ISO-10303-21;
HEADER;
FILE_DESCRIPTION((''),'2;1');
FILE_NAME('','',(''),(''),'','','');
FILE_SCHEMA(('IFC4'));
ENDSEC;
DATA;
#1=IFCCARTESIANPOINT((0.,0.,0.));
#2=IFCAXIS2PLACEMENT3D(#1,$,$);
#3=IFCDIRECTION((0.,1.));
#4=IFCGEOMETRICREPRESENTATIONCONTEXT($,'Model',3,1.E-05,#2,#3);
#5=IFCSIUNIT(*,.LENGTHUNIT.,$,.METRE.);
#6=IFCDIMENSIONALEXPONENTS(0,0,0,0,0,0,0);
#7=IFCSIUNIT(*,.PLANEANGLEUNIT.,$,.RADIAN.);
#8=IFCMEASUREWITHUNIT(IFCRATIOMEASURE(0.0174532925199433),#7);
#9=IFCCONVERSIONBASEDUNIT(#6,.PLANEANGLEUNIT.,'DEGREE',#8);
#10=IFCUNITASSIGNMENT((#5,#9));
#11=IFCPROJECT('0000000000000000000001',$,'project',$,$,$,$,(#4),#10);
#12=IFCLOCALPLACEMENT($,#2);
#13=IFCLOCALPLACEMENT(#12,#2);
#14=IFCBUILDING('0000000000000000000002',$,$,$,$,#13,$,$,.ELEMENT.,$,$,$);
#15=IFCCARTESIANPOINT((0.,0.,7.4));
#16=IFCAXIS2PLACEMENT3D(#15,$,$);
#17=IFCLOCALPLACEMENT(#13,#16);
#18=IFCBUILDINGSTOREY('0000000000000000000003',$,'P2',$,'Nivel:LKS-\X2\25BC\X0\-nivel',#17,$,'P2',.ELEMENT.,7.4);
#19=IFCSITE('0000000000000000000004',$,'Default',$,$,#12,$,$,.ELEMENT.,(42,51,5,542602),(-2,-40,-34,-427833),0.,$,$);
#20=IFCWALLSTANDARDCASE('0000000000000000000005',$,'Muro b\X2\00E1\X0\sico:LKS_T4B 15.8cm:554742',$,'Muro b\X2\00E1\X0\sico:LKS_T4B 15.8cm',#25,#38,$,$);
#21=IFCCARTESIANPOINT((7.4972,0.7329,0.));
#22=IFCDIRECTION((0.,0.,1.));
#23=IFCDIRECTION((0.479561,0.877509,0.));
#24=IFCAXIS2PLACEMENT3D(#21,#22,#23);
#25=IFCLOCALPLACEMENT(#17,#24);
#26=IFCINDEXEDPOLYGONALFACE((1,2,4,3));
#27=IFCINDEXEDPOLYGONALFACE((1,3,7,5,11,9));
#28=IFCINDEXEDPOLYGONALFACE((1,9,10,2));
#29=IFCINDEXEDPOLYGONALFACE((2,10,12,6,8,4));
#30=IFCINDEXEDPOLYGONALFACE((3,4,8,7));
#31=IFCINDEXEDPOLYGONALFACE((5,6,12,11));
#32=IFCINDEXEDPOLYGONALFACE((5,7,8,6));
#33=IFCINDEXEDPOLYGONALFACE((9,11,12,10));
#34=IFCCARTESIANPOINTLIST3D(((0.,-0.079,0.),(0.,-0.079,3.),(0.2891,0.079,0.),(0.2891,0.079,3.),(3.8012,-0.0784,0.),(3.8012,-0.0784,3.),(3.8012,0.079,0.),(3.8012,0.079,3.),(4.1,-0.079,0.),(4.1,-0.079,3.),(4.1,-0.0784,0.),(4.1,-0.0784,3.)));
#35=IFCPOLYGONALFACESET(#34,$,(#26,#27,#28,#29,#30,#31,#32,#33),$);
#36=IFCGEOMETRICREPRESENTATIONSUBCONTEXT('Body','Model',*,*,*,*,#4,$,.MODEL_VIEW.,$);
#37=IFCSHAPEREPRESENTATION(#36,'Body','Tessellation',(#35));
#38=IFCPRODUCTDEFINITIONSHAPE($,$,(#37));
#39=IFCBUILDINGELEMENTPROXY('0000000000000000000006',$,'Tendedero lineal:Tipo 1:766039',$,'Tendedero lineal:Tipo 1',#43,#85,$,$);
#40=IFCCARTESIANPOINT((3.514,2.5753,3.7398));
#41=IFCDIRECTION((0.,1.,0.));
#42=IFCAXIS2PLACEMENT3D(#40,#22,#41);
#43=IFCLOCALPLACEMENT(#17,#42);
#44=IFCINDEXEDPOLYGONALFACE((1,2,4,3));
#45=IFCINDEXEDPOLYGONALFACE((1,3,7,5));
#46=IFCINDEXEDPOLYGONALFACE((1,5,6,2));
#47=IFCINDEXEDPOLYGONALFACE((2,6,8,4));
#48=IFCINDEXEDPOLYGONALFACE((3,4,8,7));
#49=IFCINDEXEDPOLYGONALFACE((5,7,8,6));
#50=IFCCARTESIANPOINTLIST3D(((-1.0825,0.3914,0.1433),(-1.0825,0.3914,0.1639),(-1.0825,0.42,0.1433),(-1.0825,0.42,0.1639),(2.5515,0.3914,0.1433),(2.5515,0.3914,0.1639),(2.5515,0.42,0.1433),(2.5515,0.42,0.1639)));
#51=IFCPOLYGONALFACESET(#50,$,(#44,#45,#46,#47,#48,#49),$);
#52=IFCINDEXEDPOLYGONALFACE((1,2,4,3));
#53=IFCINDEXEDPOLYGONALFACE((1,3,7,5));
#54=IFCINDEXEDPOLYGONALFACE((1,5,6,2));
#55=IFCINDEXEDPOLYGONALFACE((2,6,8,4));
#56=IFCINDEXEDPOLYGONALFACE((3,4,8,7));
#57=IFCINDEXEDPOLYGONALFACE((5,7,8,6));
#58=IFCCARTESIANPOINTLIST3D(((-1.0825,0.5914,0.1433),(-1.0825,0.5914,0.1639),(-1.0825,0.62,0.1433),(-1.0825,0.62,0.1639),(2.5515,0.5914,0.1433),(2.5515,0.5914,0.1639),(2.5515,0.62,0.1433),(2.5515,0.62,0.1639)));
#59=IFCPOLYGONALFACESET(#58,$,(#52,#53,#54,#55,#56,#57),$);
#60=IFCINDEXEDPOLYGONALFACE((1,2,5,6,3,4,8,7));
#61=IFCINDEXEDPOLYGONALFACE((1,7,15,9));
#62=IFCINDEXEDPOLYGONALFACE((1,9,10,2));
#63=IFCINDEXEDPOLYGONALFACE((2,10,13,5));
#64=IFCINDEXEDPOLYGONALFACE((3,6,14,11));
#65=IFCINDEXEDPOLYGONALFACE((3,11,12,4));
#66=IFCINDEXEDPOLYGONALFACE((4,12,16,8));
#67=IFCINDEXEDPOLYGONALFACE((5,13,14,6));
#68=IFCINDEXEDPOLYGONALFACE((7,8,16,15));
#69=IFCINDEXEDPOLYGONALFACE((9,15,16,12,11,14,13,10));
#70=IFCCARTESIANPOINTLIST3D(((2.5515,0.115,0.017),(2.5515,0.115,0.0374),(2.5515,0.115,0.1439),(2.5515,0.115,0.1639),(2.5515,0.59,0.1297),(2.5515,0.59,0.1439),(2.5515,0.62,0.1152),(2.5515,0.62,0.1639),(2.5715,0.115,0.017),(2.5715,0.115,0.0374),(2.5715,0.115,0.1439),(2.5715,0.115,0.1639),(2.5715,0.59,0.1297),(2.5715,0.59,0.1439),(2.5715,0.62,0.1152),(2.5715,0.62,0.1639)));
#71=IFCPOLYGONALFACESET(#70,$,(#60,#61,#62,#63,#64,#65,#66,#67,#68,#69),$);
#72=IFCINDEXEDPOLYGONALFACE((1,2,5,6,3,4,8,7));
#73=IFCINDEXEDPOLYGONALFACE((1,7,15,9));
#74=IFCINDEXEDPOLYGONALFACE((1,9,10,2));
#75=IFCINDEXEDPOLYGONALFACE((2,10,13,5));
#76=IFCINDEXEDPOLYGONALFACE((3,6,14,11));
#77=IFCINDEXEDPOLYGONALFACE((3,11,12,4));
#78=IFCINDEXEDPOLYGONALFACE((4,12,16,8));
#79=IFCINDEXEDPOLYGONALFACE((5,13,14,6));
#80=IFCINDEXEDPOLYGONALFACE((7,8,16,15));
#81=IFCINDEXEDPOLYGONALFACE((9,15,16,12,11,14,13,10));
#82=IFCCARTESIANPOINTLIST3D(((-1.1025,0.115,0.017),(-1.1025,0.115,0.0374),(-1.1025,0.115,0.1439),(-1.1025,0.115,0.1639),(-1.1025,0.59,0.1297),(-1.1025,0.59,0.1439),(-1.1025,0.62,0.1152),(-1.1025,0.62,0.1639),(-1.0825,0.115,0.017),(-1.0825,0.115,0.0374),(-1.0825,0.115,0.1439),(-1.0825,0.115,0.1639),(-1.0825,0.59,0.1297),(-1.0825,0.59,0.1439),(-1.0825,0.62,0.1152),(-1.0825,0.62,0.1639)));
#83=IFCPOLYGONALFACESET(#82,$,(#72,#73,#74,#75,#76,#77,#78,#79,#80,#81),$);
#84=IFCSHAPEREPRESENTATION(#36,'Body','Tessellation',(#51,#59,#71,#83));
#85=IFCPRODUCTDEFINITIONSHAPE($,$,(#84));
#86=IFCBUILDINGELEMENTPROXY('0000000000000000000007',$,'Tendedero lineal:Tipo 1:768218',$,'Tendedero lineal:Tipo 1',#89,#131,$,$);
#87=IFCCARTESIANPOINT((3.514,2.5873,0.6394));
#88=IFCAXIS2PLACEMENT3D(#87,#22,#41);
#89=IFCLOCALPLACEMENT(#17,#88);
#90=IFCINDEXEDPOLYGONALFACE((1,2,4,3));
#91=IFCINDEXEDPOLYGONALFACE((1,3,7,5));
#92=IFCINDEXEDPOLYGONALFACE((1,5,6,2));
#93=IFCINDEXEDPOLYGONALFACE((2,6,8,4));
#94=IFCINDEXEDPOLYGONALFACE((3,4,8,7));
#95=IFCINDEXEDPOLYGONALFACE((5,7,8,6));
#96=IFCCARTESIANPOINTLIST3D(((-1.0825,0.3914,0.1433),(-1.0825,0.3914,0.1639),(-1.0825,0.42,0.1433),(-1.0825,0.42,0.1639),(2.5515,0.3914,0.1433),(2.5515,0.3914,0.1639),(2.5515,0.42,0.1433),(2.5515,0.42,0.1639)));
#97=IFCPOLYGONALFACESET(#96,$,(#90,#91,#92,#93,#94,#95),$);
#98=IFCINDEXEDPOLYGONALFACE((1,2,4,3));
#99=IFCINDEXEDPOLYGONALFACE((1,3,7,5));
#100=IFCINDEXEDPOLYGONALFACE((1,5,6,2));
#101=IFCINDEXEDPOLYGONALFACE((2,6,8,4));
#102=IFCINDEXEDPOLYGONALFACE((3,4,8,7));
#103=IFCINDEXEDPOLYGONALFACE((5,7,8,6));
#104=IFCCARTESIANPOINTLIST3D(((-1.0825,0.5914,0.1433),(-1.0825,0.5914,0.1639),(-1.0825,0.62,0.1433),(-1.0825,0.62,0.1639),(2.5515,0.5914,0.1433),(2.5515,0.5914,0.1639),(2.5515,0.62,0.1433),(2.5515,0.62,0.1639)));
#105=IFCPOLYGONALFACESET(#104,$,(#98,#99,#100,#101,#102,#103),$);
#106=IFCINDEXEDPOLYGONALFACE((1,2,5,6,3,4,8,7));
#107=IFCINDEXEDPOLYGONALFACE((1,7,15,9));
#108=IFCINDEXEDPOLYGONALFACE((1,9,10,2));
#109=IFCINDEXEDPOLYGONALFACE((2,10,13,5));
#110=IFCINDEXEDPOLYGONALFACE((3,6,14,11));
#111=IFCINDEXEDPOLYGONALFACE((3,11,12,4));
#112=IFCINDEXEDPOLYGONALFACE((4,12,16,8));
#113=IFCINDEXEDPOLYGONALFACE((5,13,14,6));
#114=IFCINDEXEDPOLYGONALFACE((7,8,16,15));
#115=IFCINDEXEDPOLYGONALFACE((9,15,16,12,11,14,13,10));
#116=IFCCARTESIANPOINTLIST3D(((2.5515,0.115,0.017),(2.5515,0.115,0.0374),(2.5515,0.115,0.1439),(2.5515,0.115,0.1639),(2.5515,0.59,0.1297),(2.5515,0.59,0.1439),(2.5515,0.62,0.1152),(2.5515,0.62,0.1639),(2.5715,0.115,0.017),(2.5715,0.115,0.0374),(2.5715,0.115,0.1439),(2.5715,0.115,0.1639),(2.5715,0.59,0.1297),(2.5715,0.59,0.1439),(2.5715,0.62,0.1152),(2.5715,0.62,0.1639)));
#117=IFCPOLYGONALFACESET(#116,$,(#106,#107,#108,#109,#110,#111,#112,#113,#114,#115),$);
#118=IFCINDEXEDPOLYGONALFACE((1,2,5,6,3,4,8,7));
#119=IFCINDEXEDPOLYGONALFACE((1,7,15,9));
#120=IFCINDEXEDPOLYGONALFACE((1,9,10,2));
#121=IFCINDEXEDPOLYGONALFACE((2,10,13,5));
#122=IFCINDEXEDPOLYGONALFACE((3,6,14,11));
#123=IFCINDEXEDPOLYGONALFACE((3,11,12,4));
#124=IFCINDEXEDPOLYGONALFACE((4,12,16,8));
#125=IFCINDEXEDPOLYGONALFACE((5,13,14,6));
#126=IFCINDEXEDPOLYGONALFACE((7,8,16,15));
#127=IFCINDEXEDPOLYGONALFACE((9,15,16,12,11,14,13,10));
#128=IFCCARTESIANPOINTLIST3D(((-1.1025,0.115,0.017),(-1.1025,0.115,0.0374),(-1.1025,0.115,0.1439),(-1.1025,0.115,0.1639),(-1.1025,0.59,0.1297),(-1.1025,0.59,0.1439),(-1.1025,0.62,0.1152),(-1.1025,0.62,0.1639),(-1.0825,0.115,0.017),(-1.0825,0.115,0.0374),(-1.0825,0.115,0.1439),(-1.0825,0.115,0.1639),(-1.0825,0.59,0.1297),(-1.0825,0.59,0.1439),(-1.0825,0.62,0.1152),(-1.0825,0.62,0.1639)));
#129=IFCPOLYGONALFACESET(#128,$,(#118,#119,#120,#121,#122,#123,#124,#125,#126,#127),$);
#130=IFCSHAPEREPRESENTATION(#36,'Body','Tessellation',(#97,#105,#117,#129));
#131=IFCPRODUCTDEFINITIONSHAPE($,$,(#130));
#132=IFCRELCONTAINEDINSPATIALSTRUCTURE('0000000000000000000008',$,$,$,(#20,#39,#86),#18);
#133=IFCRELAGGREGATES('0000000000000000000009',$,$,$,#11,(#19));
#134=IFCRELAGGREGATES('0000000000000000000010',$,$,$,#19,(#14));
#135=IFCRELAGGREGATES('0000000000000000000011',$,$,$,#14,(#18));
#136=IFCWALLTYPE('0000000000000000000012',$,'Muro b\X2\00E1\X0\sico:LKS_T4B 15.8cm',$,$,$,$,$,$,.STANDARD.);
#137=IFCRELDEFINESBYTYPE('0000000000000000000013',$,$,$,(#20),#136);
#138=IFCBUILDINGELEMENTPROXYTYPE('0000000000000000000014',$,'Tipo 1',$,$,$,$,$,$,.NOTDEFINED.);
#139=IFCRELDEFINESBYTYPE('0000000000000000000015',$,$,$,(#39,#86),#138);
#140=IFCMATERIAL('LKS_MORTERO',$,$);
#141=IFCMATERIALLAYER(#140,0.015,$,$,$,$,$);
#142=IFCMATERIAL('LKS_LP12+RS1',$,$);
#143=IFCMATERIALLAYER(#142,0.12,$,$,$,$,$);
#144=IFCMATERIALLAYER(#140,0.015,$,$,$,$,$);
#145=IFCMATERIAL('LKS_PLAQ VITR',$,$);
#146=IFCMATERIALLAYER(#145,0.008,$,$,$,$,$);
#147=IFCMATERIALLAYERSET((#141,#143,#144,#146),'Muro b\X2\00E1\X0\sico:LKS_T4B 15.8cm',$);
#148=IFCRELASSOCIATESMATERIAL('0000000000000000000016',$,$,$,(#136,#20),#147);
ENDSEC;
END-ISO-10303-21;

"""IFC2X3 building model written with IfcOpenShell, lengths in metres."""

from ifc_helpers import new_model, entity, si_unit, converted_unit, direction, frame, origin, origin_2d_with_axis, place, context, subcontext, project, spatial, polyline, rectangle, outline, extrude, clip, bounded_halfspace, source, transform, mapped, material, layer, layer_set, layer_usage, type_object, type_shapes, element, save


model = new_model("IFC2X3")

# Units and contexts
model_context = context("Model", 3, precision=1e-05, world=origin(), true_north=direction((0.0, 1.0)))
body_context = subcontext(model_context, "Body", "Model", "MODEL_VIEW")
ifc_project = project(units=[si_unit("LENGTHUNIT", "METRE"), converted_unit("PLANEANGLEUNIT", "DEGREE", entity("IfcRatioMeasure", 0.0174532925199433), si_unit("PLANEANGLEUNIT", "RADIAN"), dimensions=[0, 0, 0, 0, 0, 0, 0])], contexts=[model_context])

# Site, building, storey
site_placement = place(None, origin())
site = spatial("IfcSite", under=ifc_project, at=site_placement, Name="Default", CompositionType="ELEMENT", RefLatitude=(42, 51, 5, 542602), RefLongitude=(-2, -40, -34, -427833), RefElevation=0.0)
building_placement = place(site_placement, origin())
building = spatial("IfcBuilding", under=site, at=building_placement, CompositionType="ELEMENT")
storey_placement = place(building_placement, frame((0.0, 0.0, 7.4)))
storey = spatial("IfcBuildingStorey", under=building, at=storey_placement, Name="P2", ObjectType="Nivel:LKS-▼-nivel", LongName="P2", CompositionType="ELEMENT", Elevation=7.4)

# Wall
ifc_material_1 = material(Name="LKS_MORTERO")
ifc_layer_1 = layer(ifc_material_1, 0.015)
ifc_material_2 = material(Name="LKS_LP12+RS1")
ifc_layer_2 = layer(ifc_material_2, 0.12)
ifc_layer_3 = layer(ifc_material_1, 0.015)
ifc_material_3 = material(Name="LKS_PLAQ VITR")
ifc_layer_4 = layer(ifc_material_3, 0.008)
ifc_layer_set_1 = layer_set([ifc_layer_1, ifc_layer_2, ifc_layer_3, ifc_layer_4], Name="Muro básico:LKS_T4B 15.8cm")
ifc_layer_usage_1 = layer_usage(ifc_layer_set_1, "AXIS2", "POSITIVE", -0.079)
wall_type_1 = type_object("IfcWallType", Name="Muro básico:LKS_T4B 15.8cm", PredefinedType="STANDARD", material=ifc_layer_set_1)
wall_1_placement = place(storey_placement, frame((7.4972, 0.7329, 0.0), z_axis=(0.0, 0.0, 1.0), x_axis=(0.479561, 0.877509, 0.0)))
element("IfcWallStandardCase", 1, at=wall_1_placement, inside=storey, type_object=wall_type_1, material=ifc_layer_usage_1, Name="Muro básico:LKS_T4B 15.8cm:554742", ObjectType="Muro básico:LKS_T4B 15.8cm", context=body_context, shape_type="Clipping", body=[
    clip(clip(extrude(outline(polyline([(4.1, -0.079), (4.1, -0.0784), (3.8012, -0.0784), (3.8012, 0.079), (1.5591, 0.079), (1.4591, 0.079), (0.2891, 0.079), (0.0, -0.079), (4.1, -0.079)])), origin(), (0.0, 0.0, 1.0), 3.0), bounded_halfspace(frame((3.8012, -0.0784, 0.0), z_axis=(0.0, -1.0, 0.0), x_axis=(0.0, 0.0, -1.0)), True, frame((3.8012, -0.0784, 0.0), z_axis=(0.0, -1.0, 0.0), x_axis=(0.0, 0.0, -1.0)), polyline([(0.0, 0.0), (0.0, 0.2988), (-3.0, 0.2988), (-3.0, 0.0), (0.0, 0.0)]))), bounded_halfspace(frame((3.8012, -0.0784, 3.0), z_axis=(-1.0, 0.0, 0.0), x_axis=(0.0, 0.0, -1.0)), True, frame((3.8012, -0.0784, 3.0), z_axis=(-1.0, 0.0, 0.0), x_axis=(0.0, 0.0, -1.0)), polyline([(0.0, 0.0), (0.0, -0.048), (0.0, -0.1574), (3.0, -0.1574), (3.0, 0.0), (0.0, 0.0)]))),
])

# Building element proxies
building_element_proxy_type = type_object("IfcBuildingElementProxyType", Name="Tipo 1", PredefinedType="NOTDEFINED")
shared_shape = source(origin(), body_context, "Body", "SweptSolid", [
    extrude(rectangle(XDim=3.634, YDim=0.0286, at=origin_2d_with_axis()), frame((0.7345, 0.4057, 0.1433), z_axis=(0.0, 0.0, 1.0), x_axis=(-1.0, 0.0, 0.0)), (0.0, 0.0, 1.0), 0.0206),
    extrude(rectangle(XDim=3.634, YDim=0.0286, at=origin_2d_with_axis()), frame((0.7345, 0.6057, 0.1433), z_axis=(0.0, 0.0, 1.0), x_axis=(-1.0, 0.0, 0.0)), (0.0, 0.0, 1.0), 0.0206),
    extrude(outline(polyline([(-0.26, -0.0495), (0.245, -0.0495), (0.245, -0.0295), (-0.23, -0.0295), (-0.23, -0.0154), (0.245, 0.077), (0.245, 0.0973), (-0.26, -0.0008), (-0.26, -0.0495)])), frame((2.5515, 0.36, 0.1144), z_axis=(1.0, 0.0, 0.0), x_axis=(0.0, -1.0, 0.0)), (0.0, 0.0, 1.0), 0.02),
    extrude(outline(polyline([(-0.26, -0.0495), (0.245, -0.0495), (0.245, -0.0295), (-0.23, -0.0295), (-0.23, -0.0154), (0.245, 0.077), (0.245, 0.0973), (-0.26, -0.0008), (-0.26, -0.0495)])), frame((-1.1025, 0.36, 0.1144), z_axis=(1.0, 0.0, 0.0), x_axis=(0.0, -1.0, 0.0)), (0.0, 0.0, 1.0), 0.02),
])
type_shapes(building_element_proxy_type, [shared_shape])
for number, where, z_axis, x_axis, name in (
    (2, (3.514, 2.5753, 3.7398), (0.0, 0.0, 1.0), (0.0, 1.0, 0.0), "Tendedero lineal:Tipo 1:766039"),
    (3, (3.514, 2.5873, 0.6394), (0.0, 0.0, 1.0), (0.0, 1.0, 0.0), "Tendedero lineal:Tipo 1:768218"),
):
    element("IfcBuildingElementProxy", number, at=place(storey_placement, frame(where, z_axis=z_axis, x_axis=x_axis)), inside=storey, type_object=building_element_proxy_type, Name=name, ObjectType="Tendedero lineal:Tipo 1", context=body_context, shape_type="MappedRepresentation", body=[
        mapped(shared_shape, transform((0.0, 0.0, 0.0), scale=1.0)),
    ])

save(model, "model.ifc")
